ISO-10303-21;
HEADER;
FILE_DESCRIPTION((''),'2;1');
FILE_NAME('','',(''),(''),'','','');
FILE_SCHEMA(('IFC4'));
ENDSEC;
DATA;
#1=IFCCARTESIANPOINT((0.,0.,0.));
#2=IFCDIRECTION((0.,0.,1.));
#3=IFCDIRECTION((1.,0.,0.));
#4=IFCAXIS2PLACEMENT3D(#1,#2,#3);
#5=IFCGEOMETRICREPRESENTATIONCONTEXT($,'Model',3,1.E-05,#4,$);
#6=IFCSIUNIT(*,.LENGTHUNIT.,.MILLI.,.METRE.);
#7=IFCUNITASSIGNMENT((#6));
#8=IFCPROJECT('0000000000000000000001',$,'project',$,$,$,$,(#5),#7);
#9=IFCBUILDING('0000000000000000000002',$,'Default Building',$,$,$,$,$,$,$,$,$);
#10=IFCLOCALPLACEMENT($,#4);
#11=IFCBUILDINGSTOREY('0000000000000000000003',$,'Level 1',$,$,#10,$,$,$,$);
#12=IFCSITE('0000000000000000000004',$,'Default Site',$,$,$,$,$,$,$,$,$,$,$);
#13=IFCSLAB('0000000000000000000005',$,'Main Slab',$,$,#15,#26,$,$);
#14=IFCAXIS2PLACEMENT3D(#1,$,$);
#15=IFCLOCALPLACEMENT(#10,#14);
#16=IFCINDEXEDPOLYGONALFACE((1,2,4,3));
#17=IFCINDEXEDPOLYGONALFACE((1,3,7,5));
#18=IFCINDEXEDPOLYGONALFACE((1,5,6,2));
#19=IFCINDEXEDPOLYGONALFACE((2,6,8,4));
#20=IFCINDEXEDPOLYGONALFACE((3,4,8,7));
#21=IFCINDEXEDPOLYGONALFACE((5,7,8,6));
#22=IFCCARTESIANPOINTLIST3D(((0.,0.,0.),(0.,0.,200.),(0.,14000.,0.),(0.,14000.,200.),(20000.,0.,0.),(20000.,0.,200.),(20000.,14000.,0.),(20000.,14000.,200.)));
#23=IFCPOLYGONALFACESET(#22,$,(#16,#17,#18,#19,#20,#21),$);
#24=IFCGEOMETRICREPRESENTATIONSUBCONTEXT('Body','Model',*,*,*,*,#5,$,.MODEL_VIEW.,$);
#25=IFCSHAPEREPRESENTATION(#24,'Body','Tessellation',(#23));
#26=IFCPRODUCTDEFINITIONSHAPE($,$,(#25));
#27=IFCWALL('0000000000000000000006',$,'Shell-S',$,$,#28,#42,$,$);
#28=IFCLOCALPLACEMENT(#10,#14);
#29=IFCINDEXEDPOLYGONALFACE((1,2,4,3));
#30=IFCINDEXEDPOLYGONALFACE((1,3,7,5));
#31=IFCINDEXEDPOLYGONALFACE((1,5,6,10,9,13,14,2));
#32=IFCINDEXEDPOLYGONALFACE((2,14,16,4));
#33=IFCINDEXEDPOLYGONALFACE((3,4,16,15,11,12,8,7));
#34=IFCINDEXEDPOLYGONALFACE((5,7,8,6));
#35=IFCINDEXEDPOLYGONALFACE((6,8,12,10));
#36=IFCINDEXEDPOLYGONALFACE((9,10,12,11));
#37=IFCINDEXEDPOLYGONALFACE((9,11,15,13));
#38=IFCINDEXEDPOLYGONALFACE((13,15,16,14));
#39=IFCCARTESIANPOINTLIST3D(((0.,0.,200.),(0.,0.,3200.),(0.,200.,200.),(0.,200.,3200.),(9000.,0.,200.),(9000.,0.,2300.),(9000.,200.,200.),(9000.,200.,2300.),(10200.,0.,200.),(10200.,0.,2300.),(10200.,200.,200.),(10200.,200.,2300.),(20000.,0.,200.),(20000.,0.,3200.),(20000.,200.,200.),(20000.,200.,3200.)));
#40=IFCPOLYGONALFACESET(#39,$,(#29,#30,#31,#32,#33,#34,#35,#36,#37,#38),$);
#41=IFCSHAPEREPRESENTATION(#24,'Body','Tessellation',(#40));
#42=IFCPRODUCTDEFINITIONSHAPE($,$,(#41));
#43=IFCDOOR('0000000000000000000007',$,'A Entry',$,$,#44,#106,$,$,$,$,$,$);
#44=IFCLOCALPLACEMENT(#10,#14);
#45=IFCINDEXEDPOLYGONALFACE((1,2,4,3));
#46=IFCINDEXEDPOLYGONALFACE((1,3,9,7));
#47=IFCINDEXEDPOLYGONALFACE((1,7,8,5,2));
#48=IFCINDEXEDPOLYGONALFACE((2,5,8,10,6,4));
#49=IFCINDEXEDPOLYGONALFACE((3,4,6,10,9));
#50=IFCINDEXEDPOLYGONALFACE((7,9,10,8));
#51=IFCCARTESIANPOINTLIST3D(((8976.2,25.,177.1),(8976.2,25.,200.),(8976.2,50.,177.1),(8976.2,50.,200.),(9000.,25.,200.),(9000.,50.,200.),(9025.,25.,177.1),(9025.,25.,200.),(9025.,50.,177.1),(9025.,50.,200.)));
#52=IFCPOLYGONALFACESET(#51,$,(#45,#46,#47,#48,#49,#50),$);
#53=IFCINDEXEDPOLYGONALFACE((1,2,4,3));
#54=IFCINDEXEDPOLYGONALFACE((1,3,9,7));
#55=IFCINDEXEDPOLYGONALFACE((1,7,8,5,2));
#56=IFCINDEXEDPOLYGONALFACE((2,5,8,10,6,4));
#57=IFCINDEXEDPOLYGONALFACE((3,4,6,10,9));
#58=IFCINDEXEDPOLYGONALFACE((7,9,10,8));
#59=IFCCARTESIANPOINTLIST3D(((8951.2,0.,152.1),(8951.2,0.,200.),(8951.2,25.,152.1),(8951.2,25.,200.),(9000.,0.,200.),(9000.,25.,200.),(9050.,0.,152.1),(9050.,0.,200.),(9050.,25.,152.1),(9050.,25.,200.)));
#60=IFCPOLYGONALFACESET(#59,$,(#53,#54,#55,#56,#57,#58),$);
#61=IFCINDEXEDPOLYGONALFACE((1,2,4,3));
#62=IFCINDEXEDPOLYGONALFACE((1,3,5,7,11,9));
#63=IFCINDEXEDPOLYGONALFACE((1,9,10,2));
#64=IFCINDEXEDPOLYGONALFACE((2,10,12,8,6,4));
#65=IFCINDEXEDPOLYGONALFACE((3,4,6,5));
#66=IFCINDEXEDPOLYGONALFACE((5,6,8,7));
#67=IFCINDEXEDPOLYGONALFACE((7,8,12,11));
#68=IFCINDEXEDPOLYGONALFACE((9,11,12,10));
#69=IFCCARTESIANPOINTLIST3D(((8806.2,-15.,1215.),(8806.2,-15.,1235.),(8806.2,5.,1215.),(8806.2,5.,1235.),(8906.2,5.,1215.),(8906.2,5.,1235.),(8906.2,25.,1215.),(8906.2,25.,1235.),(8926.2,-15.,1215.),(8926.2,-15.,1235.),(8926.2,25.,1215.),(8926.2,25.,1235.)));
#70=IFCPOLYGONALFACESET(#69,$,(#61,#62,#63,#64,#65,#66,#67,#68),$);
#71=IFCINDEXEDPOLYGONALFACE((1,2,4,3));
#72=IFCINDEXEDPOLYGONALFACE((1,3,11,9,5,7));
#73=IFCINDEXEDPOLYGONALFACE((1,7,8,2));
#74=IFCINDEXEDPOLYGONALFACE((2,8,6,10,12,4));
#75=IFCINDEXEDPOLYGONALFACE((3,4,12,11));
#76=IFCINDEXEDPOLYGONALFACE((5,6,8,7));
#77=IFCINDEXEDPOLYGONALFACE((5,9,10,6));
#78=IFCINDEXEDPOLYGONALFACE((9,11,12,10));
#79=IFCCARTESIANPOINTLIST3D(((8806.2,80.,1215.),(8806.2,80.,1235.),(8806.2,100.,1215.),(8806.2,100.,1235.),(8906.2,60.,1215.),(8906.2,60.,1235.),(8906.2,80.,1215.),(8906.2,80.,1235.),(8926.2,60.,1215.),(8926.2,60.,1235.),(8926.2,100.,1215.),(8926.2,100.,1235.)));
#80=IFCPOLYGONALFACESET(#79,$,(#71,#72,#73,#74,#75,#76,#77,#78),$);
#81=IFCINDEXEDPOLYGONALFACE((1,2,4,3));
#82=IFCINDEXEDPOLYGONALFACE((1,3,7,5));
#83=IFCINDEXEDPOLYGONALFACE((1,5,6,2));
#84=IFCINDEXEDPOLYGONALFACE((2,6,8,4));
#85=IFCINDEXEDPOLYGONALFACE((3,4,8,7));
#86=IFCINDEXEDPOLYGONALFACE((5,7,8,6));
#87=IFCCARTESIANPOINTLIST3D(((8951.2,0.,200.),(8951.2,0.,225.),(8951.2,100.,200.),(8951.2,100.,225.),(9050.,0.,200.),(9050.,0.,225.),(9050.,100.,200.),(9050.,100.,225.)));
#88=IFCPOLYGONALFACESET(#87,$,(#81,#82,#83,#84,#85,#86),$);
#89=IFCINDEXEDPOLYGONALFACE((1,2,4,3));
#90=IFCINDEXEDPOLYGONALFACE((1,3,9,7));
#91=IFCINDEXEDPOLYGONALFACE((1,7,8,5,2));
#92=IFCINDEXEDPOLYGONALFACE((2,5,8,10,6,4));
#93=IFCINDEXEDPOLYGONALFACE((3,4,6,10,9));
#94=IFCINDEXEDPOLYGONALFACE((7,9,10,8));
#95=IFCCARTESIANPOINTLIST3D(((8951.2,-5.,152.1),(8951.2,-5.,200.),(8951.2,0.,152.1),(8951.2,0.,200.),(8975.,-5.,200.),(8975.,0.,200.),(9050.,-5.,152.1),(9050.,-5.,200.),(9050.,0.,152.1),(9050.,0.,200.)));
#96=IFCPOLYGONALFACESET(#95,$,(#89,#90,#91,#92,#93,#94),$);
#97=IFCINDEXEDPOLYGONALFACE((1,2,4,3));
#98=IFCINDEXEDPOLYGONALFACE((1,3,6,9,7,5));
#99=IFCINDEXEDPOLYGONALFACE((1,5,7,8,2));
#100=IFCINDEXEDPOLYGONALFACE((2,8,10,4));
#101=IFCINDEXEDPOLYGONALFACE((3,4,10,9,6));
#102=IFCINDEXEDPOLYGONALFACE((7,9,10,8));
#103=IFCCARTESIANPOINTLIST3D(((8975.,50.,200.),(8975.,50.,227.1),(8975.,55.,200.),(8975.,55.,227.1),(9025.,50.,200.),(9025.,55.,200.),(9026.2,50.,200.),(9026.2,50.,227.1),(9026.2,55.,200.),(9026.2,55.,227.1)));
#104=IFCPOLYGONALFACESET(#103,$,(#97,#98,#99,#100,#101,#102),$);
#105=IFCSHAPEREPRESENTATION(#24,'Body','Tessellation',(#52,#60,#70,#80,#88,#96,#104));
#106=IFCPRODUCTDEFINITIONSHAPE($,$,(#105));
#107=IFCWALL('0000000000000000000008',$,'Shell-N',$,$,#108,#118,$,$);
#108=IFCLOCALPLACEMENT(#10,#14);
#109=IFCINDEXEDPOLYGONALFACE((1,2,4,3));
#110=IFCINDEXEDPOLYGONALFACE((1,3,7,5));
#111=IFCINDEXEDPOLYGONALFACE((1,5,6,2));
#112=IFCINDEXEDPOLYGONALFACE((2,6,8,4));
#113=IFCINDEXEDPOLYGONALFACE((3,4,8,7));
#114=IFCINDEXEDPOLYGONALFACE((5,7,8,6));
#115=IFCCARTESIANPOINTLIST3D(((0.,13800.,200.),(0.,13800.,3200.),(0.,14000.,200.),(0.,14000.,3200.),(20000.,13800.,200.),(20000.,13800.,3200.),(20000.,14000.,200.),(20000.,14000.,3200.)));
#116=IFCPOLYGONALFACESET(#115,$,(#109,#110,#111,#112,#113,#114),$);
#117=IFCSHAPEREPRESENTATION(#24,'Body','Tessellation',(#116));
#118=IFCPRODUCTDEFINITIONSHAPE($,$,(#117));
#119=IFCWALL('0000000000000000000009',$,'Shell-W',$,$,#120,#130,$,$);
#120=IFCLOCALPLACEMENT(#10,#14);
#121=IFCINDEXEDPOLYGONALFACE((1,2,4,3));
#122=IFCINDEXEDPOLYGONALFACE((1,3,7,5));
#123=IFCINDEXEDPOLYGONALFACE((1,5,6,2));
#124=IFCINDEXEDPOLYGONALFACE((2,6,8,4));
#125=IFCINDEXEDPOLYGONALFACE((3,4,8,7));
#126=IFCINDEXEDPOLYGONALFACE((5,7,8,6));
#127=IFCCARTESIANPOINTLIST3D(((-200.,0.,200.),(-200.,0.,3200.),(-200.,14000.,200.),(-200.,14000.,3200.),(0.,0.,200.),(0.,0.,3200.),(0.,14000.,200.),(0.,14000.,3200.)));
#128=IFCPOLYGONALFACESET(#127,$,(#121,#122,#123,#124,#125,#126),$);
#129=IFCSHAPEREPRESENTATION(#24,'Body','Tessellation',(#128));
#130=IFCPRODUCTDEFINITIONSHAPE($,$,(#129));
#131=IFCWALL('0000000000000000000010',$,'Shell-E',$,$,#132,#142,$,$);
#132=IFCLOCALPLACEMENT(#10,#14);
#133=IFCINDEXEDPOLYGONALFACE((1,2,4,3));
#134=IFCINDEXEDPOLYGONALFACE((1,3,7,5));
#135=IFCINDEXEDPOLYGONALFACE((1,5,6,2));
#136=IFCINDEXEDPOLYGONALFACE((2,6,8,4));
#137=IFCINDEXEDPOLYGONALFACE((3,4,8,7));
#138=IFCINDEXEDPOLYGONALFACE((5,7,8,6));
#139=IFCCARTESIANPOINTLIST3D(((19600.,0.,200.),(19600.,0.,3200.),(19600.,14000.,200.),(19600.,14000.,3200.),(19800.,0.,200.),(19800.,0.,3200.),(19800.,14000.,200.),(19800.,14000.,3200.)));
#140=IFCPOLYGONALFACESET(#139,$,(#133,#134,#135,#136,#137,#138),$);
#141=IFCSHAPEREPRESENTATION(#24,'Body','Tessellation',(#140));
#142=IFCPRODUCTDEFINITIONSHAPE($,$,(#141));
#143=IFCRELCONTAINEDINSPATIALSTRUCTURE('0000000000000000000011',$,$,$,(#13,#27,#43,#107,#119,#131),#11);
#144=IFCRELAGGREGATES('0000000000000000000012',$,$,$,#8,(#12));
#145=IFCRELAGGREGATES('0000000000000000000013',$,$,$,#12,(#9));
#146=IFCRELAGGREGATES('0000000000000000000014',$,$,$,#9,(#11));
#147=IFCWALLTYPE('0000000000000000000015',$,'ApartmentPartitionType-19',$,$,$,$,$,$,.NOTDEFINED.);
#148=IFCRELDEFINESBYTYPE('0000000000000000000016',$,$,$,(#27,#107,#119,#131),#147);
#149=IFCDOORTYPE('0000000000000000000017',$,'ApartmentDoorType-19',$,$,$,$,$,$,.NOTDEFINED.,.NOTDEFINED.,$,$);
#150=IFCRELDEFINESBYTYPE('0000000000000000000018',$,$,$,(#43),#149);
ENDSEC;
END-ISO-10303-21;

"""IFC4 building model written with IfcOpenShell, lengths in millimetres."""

from ifc_helpers import new_model, si_unit, frame, origin_with_axes, place, context, subcontext, project, spatial, line, indexed_curve, outline, extrude, type_object, element, fill, save


model = new_model("IFC4")

# Units and contexts
model_context = context("Model", 3, precision=1e-05, world=origin_with_axes())
body_context = subcontext(model_context, "Body", "Model", "MODEL_VIEW")
ifc_project = project(units=[si_unit("LENGTHUNIT", "METRE", prefix="MILLI")], contexts=[model_context])

# Site, building, storey
site = spatial("IfcSite", under=ifc_project, Name="Default Site")
building = spatial("IfcBuilding", under=site, Name="Default Building")
storey_placement = place(None, origin_with_axes())
storey = spatial("IfcBuildingStorey", under=building, at=storey_placement, Name="Level 1")

# Slab
slab_placement = place(storey_placement, origin_with_axes())
element("IfcSlab", 1, at=slab_placement, inside=storey, Name="Main Slab", context=body_context, shape_type="SweptSolid", body=[
    extrude(outline(indexed_curve([(0.0, 0.0), (20000.0, 0.0), (20000.0, 14000.0), (0.0, 14000.0), (0.0, 0.0)])), None, (0.0, 0.0, 1.0), 200.0),
])

# Wall, opening, door
wall_type = type_object("IfcWallType", Name="ApartmentPartitionType-19", PredefinedType="NOTDEFINED")
wall_1_placement = place(storey_placement, frame((0.0, 0.0, 200.0), z_axis=(0.0, 0.0, 1.0), x_axis=(1.0, 0.0, 0.0)))
wall_1 = element("IfcWall", 2, at=wall_1_placement, inside=storey, type_object=wall_type, Name="Shell-S", context=body_context, shape_type="SweptSolid", body=[
    extrude(outline(indexed_curve([(0.0, 0.0), (20000.0, 0.0), (20000.0, 200.0), (0.0, 200.0), (0.0, 0.0)])), None, (0.0, 0.0, 1.0), 3000.0),
])
opening_placement = place(wall_1_placement, origin_with_axes())
opening = element("IfcOpeningElement", 3, at=opening_placement, cuts=wall_1, context=body_context, shape_type="SweptSolid", body=[
    extrude(outline(indexed_curve([(9000.0, 0.0), (10200.0, 0.0), (10200.0, 200.0), (9000.0, 200.0), (9000.0, 0.0)])), None, (0.0, 0.0, 1.0), 2100.0),
])
door_type = type_object("IfcDoorType", Name="ApartmentDoorType-19", OperationType="NOTDEFINED", PredefinedType="NOTDEFINED")
door_placement = place(storey_placement, frame((9000.0, 0.0, 200.0), z_axis=(0.0, 0.0, 1.0), x_axis=(1.0, 0.0, 0.0)))
door = element("IfcDoor", 4, at=door_placement, inside=storey, type_object=door_type, Name="A Entry", context=body_context, shape_type="SweptSolid", body=[
    extrude(outline(indexed_curve([(0.0, 0.0), (0.0, 2.1), (1.2, 2.1), (1.2, 0.0), (-23.8, 0.0), (-23.8, -22.9), (25.0, -22.9), (25.0, 0.0)], segments=[line(1, 2, 3, 4, 5, 6, 7, 8, 1)])), frame((0.0, 25.0, 0.0), z_axis=(0.0, -1.0, 0.0), x_axis=(1.0, 0.0, 0.0)), (0.0, 0.0, -1.0), 25.0),
    extrude(outline(indexed_curve([(0.0, 0.0), (0.0, 2.1), (1.2, 2.1), (1.2, 0.0), (-48.8, 0.0), (-48.8, -47.9), (50.0, -47.9), (50.0, 0.0)], segments=[line(1, 2, 3, 4, 5, 6, 7, 8, 1)])), frame((0.0, 0.0, 0.0), z_axis=(0.0, -1.0, 0.0), x_axis=(1.0, 0.0, 0.0)), (0.0, 0.0, -1.0), 25.0),
    extrude(outline(indexed_curve([(0.0, 0.0), (-48.8, 0.0), (-48.8, 35.0), (0.0, 35.0)], segments=[line(1, 2, 3, 4, 1)])), frame((25.0, 25.0, 25.0), z_axis=(0.0, 0.0, 1.0), x_axis=(1.0, 0.0, 0.0)), (0.0, 0.0, 1.0), -47.9),
    extrude(outline(indexed_curve([(0.0, 0.0), (0.0, -40.0), (-120.0, -40.0), (-120.0, -20.0), (-20.0, -20.0), (-20.0, 0.0)], segments=[line(1, 2, 3, 4, 5, 6, 1)])), frame((-73.8, 25.0, 1015.0), z_axis=(0.0, 0.0, 1.0), x_axis=(1.0, 0.0, 0.0)), (0.0, 0.0, 1.0), 20.0),
    extrude(outline(indexed_curve([(0.0, 0.0), (0.0, 40.0), (-120.0, 40.0), (-120.0, 20.0), (-20.0, 20.0), (-20.0, 0.0)], segments=[line(1, 2, 3, 4, 5, 6, 1)])), frame((-73.8, 60.0, 1015.0), z_axis=(0.0, 0.0, 1.0), x_axis=(1.0, 0.0, 0.0)), (0.0, 0.0, 1.0), 20.0),
    extrude(outline(indexed_curve([(0.0, 0.0), (-98.8, 0.0), (-98.8, 100.0), (0.0, 100.0)], segments=[line(1, 2, 3, 4, 1)])), frame((50.0, 0.0, 0.0), z_axis=(0.0, 0.0, 1.0), x_axis=(1.0, 0.0, 0.0)), (0.0, 0.0, 1.0), 25.0),
    extrude(outline(indexed_curve([(0.0, 0.0), (0.0, 27.1), (51.2, 27.1), (51.2, 0.0), (-23.8, 0.0), (-23.8, -47.9), (75.0, -47.9), (75.0, 0.0)], segments=[line(1, 2, 3, 4, 5, 6, 7, 8, 1)])), frame((-25.0, -5.0, 0.0), z_axis=(0.0, -1.0, 0.0), x_axis=(1.0, 0.0, 0.0)), (0.0, 0.0, -1.0), 5.0),
    extrude(outline(indexed_curve([(0.0, 0.0), (0.0, 27.1), (51.2, 27.1), (51.2, 0.0), (1.2, 0.0), (1.2, -22.9), (50.0, -22.9), (50.0, 0.0)], segments=[line(1, 2, 3, 4, 5, 6, 7, 8, 1)])), frame((-25.0, 50.0, 0.0), z_axis=(0.0, -1.0, 0.0), x_axis=(1.0, 0.0, 0.0)), (0.0, 0.0, -1.0), 5.0),
])
fill(opening, door)

# Walls
wall_2_placement = place(storey_placement, frame((0.0, 0.0, 200.0), z_axis=(0.0, 0.0, 1.0), x_axis=(1.0, 0.0, 0.0)))
element("IfcWall", 5, at=wall_2_placement, inside=storey, type_object=wall_type, Name="Shell-N", context=body_context, shape_type="SweptSolid", body=[
    extrude(outline(indexed_curve([(0.0, 13800.0), (20000.0, 13800.0), (20000.0, 14000.0), (0.0, 14000.0), (0.0, 13800.0)])), None, (0.0, 0.0, 1.0), 3000.0),
])
wall_3_placement = place(storey_placement, frame((0.0, 0.0, 200.0), z_axis=(0.0, 0.0, 1.0), x_axis=(1.0, 0.0, 0.0)))
element("IfcWall", 6, at=wall_3_placement, inside=storey, type_object=wall_type, Name="Shell-W", context=body_context, shape_type="SweptSolid", body=[
    extrude(outline(indexed_curve([(0.0, 0.0), (0.0, 14000.0), (-200.0, 14000.0), (-200.0, 0.0), (0.0, 0.0)])), None, (0.0, 0.0, 1.0), 3000.0),
])
wall_4_placement = place(storey_placement, frame((0.0, 0.0, 200.0), z_axis=(0.0, 0.0, 1.0), x_axis=(1.0, 0.0, 0.0)))
element("IfcWall", 7, at=wall_4_placement, inside=storey, type_object=wall_type, Name="Shell-E", context=body_context, shape_type="SweptSolid", body=[
    extrude(outline(indexed_curve([(19800.0, 0.0), (19800.0, 14000.0), (19600.0, 14000.0), (19600.0, 0.0), (19800.0, 0.0)])), None, (0.0, 0.0, 1.0), 3000.0),
])

save(model, "model.ifc")
